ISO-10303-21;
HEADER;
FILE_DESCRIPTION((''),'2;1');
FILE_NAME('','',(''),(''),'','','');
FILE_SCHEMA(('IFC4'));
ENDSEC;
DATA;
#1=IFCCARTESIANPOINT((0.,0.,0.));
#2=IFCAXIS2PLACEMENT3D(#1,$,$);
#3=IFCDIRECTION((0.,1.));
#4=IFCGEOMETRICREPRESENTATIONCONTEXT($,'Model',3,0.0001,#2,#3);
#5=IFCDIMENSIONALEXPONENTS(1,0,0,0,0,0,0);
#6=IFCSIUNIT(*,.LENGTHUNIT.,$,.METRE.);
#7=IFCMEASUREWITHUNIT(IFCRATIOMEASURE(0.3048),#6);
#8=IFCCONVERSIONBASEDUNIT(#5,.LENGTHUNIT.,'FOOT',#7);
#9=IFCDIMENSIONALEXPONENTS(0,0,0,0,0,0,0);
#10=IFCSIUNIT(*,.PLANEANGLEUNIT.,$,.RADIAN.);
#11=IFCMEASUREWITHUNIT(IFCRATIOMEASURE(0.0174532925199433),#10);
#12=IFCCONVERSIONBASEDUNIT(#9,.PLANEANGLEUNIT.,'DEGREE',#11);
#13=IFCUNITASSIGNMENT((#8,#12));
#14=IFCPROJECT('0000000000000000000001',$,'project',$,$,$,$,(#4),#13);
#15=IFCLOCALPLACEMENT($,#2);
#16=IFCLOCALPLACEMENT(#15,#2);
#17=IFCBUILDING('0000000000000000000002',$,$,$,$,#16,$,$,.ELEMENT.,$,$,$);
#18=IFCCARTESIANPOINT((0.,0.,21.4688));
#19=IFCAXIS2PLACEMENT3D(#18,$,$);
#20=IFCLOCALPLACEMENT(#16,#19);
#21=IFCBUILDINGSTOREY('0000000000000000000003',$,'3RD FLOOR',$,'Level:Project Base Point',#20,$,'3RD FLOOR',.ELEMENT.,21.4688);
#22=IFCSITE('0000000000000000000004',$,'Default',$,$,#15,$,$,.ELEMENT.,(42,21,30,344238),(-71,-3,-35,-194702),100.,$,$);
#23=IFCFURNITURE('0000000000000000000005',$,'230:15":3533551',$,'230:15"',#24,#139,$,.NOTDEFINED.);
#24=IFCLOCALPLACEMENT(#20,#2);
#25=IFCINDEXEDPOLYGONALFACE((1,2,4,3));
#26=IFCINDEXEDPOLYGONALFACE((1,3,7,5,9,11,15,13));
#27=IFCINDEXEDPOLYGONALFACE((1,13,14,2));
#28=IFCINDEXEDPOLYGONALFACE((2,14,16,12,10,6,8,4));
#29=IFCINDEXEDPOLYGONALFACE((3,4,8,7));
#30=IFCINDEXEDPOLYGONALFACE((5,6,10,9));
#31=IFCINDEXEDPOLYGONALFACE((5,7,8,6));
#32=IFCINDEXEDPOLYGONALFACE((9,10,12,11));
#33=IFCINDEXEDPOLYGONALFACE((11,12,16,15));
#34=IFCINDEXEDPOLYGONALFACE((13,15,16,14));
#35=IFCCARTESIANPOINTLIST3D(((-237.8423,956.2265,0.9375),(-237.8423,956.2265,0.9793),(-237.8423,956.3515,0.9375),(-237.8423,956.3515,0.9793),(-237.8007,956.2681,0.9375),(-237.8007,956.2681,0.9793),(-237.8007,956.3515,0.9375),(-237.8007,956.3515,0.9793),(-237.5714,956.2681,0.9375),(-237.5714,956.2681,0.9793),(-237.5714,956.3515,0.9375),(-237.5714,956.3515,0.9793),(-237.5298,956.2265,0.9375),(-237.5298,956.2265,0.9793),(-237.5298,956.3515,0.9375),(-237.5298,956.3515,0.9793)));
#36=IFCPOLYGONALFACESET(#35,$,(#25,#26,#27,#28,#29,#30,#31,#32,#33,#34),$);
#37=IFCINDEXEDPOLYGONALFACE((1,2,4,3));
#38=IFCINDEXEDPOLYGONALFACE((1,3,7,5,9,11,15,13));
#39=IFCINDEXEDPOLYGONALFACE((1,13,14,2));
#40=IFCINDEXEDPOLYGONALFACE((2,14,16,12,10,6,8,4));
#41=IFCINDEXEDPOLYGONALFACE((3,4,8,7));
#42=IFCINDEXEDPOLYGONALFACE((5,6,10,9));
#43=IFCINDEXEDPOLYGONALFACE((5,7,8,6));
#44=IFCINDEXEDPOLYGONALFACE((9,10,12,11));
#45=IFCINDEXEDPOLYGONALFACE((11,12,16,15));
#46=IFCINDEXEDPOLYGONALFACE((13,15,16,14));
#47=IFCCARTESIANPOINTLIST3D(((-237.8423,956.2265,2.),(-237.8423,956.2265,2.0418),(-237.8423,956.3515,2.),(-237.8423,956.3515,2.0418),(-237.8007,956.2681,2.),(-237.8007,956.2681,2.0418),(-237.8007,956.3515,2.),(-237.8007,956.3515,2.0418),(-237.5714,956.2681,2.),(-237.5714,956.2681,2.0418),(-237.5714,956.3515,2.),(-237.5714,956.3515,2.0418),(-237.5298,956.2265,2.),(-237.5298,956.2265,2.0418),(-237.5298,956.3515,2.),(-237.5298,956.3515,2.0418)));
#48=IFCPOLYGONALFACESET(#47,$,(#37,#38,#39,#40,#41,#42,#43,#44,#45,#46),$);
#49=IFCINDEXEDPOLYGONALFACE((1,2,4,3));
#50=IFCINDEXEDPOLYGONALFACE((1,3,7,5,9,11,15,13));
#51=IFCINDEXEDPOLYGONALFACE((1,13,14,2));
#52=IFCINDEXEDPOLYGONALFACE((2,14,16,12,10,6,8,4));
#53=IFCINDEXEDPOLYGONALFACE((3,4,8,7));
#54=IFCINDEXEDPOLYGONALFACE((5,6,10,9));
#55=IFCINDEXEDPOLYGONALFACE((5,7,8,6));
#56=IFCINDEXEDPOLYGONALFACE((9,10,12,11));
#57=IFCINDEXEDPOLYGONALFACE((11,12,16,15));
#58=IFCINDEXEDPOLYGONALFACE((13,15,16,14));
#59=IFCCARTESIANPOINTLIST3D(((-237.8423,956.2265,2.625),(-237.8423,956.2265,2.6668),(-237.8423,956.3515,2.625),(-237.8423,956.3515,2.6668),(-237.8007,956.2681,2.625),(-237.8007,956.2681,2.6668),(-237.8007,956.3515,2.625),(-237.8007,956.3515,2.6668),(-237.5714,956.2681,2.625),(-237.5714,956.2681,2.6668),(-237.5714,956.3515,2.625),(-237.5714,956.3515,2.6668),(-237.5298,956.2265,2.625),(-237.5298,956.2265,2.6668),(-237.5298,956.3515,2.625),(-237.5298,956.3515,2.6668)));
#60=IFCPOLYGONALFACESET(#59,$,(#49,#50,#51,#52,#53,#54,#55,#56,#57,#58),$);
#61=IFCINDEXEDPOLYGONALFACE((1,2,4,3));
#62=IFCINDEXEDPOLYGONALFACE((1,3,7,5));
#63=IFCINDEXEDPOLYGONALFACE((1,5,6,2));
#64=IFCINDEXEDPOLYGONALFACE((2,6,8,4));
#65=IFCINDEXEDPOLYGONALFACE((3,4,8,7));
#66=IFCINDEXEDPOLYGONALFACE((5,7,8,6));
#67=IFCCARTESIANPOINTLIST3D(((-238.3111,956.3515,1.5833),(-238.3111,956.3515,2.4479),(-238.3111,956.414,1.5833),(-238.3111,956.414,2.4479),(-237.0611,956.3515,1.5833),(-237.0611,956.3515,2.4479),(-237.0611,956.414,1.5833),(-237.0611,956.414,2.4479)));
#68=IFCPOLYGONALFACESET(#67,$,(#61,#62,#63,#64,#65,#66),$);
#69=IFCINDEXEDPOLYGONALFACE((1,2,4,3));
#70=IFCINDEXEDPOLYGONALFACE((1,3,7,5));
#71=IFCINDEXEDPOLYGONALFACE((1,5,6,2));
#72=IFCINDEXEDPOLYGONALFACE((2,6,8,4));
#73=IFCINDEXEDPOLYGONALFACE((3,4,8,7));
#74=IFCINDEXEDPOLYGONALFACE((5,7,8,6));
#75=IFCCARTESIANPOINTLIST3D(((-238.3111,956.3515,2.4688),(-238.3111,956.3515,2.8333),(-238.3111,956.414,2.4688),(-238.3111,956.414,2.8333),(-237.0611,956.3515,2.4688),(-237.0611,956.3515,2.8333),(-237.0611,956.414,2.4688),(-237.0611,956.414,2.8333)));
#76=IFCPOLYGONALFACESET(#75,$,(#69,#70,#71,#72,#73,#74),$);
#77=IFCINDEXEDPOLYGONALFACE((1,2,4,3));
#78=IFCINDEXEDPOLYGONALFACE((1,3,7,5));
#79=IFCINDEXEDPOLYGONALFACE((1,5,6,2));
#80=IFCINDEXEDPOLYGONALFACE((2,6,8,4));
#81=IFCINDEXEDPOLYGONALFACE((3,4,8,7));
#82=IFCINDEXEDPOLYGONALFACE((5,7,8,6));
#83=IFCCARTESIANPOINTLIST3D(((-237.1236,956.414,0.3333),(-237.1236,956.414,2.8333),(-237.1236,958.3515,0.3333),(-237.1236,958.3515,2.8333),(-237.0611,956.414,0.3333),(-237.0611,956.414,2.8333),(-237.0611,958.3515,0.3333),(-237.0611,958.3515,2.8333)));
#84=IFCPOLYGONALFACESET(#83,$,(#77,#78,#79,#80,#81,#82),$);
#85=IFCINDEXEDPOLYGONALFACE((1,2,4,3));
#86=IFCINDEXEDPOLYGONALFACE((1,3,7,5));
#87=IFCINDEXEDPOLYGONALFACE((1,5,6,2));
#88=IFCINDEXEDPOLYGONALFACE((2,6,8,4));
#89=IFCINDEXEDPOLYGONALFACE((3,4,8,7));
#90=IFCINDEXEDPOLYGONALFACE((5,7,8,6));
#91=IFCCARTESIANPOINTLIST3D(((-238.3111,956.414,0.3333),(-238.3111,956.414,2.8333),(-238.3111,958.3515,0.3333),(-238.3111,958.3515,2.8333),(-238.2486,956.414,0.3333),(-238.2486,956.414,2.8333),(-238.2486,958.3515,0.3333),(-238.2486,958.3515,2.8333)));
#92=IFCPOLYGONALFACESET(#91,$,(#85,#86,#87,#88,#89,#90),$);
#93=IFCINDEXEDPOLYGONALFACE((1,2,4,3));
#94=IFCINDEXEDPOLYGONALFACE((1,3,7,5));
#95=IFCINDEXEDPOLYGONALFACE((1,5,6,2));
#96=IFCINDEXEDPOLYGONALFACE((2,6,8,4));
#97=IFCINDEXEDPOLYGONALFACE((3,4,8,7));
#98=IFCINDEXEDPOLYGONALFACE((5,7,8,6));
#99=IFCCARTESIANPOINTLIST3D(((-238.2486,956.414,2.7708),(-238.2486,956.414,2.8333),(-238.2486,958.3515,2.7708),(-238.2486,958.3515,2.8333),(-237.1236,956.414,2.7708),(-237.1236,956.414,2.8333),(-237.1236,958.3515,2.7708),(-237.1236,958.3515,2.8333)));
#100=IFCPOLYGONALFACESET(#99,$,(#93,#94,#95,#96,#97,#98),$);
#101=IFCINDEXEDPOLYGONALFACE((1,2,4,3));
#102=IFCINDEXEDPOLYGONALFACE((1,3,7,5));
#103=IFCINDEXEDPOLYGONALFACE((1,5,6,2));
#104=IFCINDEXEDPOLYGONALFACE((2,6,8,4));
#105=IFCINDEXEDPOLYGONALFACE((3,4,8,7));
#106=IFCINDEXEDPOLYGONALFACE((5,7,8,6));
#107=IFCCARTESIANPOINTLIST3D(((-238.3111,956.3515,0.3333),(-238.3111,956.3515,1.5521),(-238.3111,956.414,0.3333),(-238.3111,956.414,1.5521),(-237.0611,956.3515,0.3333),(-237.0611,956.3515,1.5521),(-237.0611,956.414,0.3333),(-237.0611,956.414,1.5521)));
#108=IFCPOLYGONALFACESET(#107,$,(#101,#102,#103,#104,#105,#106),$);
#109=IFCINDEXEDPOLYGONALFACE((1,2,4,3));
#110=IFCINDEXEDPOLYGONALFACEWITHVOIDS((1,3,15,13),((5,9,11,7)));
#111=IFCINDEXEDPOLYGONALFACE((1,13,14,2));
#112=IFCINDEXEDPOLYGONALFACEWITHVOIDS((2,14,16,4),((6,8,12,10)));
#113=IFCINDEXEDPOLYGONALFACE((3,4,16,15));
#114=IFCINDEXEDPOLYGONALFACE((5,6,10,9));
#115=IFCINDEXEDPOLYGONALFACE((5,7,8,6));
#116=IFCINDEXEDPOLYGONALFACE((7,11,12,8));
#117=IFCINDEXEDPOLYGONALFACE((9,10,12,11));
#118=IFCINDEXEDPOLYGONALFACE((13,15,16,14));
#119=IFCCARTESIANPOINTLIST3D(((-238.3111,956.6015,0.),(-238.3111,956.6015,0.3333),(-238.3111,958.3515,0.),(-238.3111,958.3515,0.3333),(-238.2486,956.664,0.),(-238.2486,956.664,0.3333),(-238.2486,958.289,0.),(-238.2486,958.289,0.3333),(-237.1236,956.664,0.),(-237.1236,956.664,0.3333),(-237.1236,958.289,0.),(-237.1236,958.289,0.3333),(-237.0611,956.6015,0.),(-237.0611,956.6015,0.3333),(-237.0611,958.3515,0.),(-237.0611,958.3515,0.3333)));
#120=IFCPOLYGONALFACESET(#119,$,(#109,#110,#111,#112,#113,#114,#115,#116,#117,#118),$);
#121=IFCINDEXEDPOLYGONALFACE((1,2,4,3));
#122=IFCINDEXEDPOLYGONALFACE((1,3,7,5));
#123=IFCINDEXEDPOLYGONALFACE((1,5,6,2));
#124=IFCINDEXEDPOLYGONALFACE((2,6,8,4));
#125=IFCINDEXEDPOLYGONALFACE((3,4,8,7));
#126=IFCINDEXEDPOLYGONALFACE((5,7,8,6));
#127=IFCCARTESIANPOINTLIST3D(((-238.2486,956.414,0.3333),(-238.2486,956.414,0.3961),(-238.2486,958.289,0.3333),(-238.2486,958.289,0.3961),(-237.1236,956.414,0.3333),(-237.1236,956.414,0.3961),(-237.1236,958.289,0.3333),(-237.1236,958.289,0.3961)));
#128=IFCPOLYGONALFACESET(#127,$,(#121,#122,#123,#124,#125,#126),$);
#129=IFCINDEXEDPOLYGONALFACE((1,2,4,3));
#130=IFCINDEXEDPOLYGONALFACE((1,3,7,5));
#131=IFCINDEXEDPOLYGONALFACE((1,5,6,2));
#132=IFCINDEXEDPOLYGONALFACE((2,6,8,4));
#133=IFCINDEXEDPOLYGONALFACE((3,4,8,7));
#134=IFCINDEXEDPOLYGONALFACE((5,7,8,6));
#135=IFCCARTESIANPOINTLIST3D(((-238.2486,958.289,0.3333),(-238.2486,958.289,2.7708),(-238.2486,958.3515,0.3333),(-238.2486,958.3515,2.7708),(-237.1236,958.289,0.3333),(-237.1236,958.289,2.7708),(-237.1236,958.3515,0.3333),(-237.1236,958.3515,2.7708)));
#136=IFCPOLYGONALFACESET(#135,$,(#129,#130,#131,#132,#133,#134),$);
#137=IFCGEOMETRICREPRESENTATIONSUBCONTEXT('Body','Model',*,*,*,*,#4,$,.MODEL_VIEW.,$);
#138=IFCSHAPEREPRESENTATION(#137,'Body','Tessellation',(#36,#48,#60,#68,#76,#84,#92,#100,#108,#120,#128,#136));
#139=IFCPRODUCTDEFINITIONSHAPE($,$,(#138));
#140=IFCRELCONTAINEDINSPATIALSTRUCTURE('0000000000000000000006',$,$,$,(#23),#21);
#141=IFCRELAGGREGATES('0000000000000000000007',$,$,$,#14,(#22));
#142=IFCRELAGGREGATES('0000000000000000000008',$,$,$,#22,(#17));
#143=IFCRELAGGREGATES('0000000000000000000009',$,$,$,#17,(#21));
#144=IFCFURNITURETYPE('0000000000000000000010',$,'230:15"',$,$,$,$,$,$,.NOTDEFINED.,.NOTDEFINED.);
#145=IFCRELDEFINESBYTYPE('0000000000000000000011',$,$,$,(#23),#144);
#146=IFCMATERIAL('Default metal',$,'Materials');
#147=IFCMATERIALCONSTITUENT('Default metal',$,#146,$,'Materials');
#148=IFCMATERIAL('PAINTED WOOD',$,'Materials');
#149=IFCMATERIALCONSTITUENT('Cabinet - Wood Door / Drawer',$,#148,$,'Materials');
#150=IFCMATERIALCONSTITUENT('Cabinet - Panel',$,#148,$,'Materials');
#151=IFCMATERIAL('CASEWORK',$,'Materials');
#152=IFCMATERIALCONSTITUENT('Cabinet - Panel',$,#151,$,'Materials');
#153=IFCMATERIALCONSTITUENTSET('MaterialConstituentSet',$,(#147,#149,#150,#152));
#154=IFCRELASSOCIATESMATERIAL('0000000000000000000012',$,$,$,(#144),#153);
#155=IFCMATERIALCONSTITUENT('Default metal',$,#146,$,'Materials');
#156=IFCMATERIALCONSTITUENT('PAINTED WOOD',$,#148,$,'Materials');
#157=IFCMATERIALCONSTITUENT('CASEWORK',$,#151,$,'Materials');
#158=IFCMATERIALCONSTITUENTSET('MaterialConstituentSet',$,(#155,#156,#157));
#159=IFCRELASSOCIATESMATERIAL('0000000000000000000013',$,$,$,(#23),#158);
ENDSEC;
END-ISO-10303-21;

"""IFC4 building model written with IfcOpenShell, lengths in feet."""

from ifc_helpers import new_model, entity, si_unit, converted_unit, direction, frame, frame_2d, origin, origin_2d_with_axis, place, context, subcontext, project, spatial, polyline, rectangle, outline, extrude, source, transform, mapped, material, constituent, constituent_set, type_object, type_shapes, element, save


model = new_model("IFC4")

# Units and contexts
model_context = context("Model", 3, precision=0.0001, world=origin(), true_north=direction((0.0, 1.0)))
body_context = subcontext(model_context, "Body", "Model", "MODEL_VIEW")
ifc_project = project(units=[converted_unit("LENGTHUNIT", "FOOT", entity("IfcRatioMeasure", 0.3048), si_unit("LENGTHUNIT", "METRE"), dimensions=[1, 0, 0, 0, 0, 0, 0]), converted_unit("PLANEANGLEUNIT", "DEGREE", entity("IfcRatioMeasure", 0.0174532925199433), si_unit("PLANEANGLEUNIT", "RADIAN"), dimensions=[0, 0, 0, 0, 0, 0, 0])], contexts=[model_context])

# Site, building, storey
site_placement = place(None, origin())
site = spatial("IfcSite", under=ifc_project, at=site_placement, Name="Default", CompositionType="ELEMENT", RefLatitude=(42, 21, 30, 344238), RefLongitude=(-71, -3, -35, -194702), RefElevation=100.0)
building_placement = place(site_placement, origin())
building = spatial("IfcBuilding", under=site, at=building_placement, CompositionType="ELEMENT")
storey_placement = place(building_placement, frame((0.0, 0.0, 21.4688)))
storey = spatial("IfcBuildingStorey", under=building, at=storey_placement, Name="3RD FLOOR", ObjectType="Level:Project Base Point", LongName="3RD FLOOR", CompositionType="ELEMENT", Elevation=21.4688)

# Furniture
ifc_material_1 = material(Name="Default metal", Category="Materials")
ifc_material_2 = material(Name="PAINTED WOOD", Category="Materials")
ifc_material_3 = material(Name="CASEWORK", Category="Materials")
ifc_constituent_1 = constituent(ifc_material_1, Name="Default metal", Category="Materials")
ifc_constituent_2 = constituent(ifc_material_2, Name="PAINTED WOOD", Category="Materials")
ifc_constituent_3 = constituent(ifc_material_3, Name="CASEWORK", Category="Materials")
ifc_constituent_set_1 = constituent_set(constituents=[ifc_constituent_1, ifc_constituent_2, ifc_constituent_3], Name="MaterialConstituentSet")
ifc_constituent_4 = constituent(ifc_material_1, Name="Default metal", Category="Materials")
ifc_constituent_5 = constituent(ifc_material_2, Name="Cabinet - Wood Door / Drawer", Category="Materials")
ifc_constituent_6 = constituent(ifc_material_2, Name="Cabinet - Panel", Category="Materials")
ifc_constituent_7 = constituent(ifc_material_3, Name="Cabinet - Panel", Category="Materials")
ifc_constituent_set_2 = constituent_set(constituents=[ifc_constituent_4, ifc_constituent_5, ifc_constituent_6, ifc_constituent_7], Name="MaterialConstituentSet")
furniture_type_1 = type_object("IfcFurnitureType", Name="230:15\"", AssemblyPlace="NOTDEFINED", PredefinedType="NOTDEFINED", material=ifc_constituent_set_2)
shared_shape_1 = source(origin(), body_context, "Body", "SweptSolid", [
    extrude(outline(polyline([(-0.1562, -0.0521), (-0.1146, -0.0521), (-0.1146, 0.0313), (0.1146, 0.0313), (0.1146, -0.0521), (0.1562, -0.0521), (0.1562, 0.0729), (-0.1562, 0.0729), (-0.1562, -0.0521)])), frame((0.0615, 2.0521, 0.9375)), (0.0, 0.0, 1.0), 0.0418),
    extrude(outline(polyline([(-0.1562, -0.0521), (-0.1146, -0.0521), (-0.1146, 0.0313), (0.1146, 0.0313), (0.1146, -0.0521), (0.1562, -0.0521), (0.1562, 0.0729), (-0.1562, 0.0729), (-0.1562, -0.0521)])), frame((0.0615, 2.0521, 2.0)), (0.0, 0.0, 1.0), 0.0418),
    extrude(outline(polyline([(-0.1562, -0.0521), (-0.1146, -0.0521), (-0.1146, 0.0313), (0.1146, 0.0313), (0.1146, -0.0521), (0.1562, -0.0521), (0.1562, 0.0729), (-0.1562, 0.0729), (-0.1562, -0.0521)])), frame((0.0615, 2.0521, 2.625)), (0.0, 0.0, 1.0), 0.0418),
    extrude(rectangle(XDim=1.25, YDim=0.0625, at=frame_2d((0.0, 0.0), x_axis=(1.0, 0.0))), frame((0.0615, 1.9688, 1.5833), z_axis=(0.0, 0.0, 1.0), x_axis=(-1.0, 0.0, 0.0)), (0.0, 0.0, 1.0), 0.8646),
    extrude(rectangle(XDim=1.25, YDim=0.0625, at=frame_2d((0.0, 0.0), x_axis=(1.0, 0.0))), frame((0.0615, 1.9688, 2.4688), z_axis=(0.0, 0.0, 1.0), x_axis=(-1.0, 0.0, 0.0)), (0.0, 0.0, 1.0), 0.3646),
    extrude(rectangle(XDim=1.9375, YDim=0.0625, at=frame_2d((0.0, 0.0), x_axis=(1.0, 0.0))), frame((-0.5323, 0.9687, 0.3333), z_axis=(0.0, 0.0, 1.0), x_axis=(0.0, -1.0, 0.0)), (0.0, 0.0, 1.0), 2.5),
    extrude(rectangle(XDim=1.9375, YDim=0.0625, at=frame_2d((0.0, 0.0), x_axis=(1.0, 0.0))), frame((0.6552, 0.9687, 0.3333), z_axis=(0.0, 0.0, 1.0), x_axis=(0.0, -1.0, 0.0)), (0.0, 0.0, 1.0), 2.5),
    extrude(rectangle(XDim=1.9375, YDim=1.125, at=origin_2d_with_axis()), frame((0.0615, 0.9687, 2.7708), z_axis=(0.0, 0.0, 1.0), x_axis=(0.0, 1.0, 0.0)), (0.0, 0.0, 1.0), 0.0625),
    extrude(rectangle(XDim=1.25, YDim=0.0625, at=frame_2d((0.0, 0.0), x_axis=(1.0, 0.0))), frame((0.0615, 1.9688, 0.3333), z_axis=(0.0, 0.0, 1.0), x_axis=(-1.0, 0.0, 0.0)), (0.0, 0.0, 1.0), 1.2187),
    extrude(outline(polyline([(-0.875, -0.625), (0.875, -0.625), (0.875, 0.625), (-0.875, 0.625), (-0.875, -0.625)]), holes=[polyline([(-0.8125, -0.5625), (-0.8125, 0.5625), (0.8125, 0.5625), (0.8125, -0.5625), (-0.8125, -0.5625)])]), frame((0.0615, 0.875, 0.0), z_axis=(0.0, 0.0, 1.0), x_axis=(0.0, -1.0, 0.0)), (0.0, 0.0, 1.0), 0.3333),
    extrude(rectangle(XDim=1.875, YDim=1.125, at=origin_2d_with_axis()), frame((0.0615, 1.0, 0.3333), z_axis=(0.0, 0.0, 1.0), x_axis=(0.0, 1.0, 0.0)), (0.0, 0.0, 1.0), 0.0627),
    extrude(rectangle(XDim=1.125, YDim=0.0625, at=origin_2d_with_axis()), frame((0.0615, 0.0312, 0.3333), z_axis=(0.0, 0.0, 1.0), x_axis=(-1.0, 0.0, 0.0)), (0.0, 0.0, 1.0), 2.4375),
])
type_shapes(furniture_type_1, [shared_shape_1])
furniture_1_placement = place(storey_placement, frame((-237.6246, 958.3515, 0.0), z_axis=(0.0, 0.0, 1.0), x_axis=(-1.0, 0.0, 0.0)))
element("IfcFurniture", 1, at=furniture_1_placement, inside=storey, type_object=furniture_type_1, material=ifc_constituent_set_1, Name="230:15\":3533551", ObjectType="230:15\"", PredefinedType="NOTDEFINED", context=body_context, shape_type="MappedRepresentation", body=[
    mapped(shared_shape_1, transform((0.0, 0.0, 0.0), scale=1.0)),
])

save(model, "model.ifc")
